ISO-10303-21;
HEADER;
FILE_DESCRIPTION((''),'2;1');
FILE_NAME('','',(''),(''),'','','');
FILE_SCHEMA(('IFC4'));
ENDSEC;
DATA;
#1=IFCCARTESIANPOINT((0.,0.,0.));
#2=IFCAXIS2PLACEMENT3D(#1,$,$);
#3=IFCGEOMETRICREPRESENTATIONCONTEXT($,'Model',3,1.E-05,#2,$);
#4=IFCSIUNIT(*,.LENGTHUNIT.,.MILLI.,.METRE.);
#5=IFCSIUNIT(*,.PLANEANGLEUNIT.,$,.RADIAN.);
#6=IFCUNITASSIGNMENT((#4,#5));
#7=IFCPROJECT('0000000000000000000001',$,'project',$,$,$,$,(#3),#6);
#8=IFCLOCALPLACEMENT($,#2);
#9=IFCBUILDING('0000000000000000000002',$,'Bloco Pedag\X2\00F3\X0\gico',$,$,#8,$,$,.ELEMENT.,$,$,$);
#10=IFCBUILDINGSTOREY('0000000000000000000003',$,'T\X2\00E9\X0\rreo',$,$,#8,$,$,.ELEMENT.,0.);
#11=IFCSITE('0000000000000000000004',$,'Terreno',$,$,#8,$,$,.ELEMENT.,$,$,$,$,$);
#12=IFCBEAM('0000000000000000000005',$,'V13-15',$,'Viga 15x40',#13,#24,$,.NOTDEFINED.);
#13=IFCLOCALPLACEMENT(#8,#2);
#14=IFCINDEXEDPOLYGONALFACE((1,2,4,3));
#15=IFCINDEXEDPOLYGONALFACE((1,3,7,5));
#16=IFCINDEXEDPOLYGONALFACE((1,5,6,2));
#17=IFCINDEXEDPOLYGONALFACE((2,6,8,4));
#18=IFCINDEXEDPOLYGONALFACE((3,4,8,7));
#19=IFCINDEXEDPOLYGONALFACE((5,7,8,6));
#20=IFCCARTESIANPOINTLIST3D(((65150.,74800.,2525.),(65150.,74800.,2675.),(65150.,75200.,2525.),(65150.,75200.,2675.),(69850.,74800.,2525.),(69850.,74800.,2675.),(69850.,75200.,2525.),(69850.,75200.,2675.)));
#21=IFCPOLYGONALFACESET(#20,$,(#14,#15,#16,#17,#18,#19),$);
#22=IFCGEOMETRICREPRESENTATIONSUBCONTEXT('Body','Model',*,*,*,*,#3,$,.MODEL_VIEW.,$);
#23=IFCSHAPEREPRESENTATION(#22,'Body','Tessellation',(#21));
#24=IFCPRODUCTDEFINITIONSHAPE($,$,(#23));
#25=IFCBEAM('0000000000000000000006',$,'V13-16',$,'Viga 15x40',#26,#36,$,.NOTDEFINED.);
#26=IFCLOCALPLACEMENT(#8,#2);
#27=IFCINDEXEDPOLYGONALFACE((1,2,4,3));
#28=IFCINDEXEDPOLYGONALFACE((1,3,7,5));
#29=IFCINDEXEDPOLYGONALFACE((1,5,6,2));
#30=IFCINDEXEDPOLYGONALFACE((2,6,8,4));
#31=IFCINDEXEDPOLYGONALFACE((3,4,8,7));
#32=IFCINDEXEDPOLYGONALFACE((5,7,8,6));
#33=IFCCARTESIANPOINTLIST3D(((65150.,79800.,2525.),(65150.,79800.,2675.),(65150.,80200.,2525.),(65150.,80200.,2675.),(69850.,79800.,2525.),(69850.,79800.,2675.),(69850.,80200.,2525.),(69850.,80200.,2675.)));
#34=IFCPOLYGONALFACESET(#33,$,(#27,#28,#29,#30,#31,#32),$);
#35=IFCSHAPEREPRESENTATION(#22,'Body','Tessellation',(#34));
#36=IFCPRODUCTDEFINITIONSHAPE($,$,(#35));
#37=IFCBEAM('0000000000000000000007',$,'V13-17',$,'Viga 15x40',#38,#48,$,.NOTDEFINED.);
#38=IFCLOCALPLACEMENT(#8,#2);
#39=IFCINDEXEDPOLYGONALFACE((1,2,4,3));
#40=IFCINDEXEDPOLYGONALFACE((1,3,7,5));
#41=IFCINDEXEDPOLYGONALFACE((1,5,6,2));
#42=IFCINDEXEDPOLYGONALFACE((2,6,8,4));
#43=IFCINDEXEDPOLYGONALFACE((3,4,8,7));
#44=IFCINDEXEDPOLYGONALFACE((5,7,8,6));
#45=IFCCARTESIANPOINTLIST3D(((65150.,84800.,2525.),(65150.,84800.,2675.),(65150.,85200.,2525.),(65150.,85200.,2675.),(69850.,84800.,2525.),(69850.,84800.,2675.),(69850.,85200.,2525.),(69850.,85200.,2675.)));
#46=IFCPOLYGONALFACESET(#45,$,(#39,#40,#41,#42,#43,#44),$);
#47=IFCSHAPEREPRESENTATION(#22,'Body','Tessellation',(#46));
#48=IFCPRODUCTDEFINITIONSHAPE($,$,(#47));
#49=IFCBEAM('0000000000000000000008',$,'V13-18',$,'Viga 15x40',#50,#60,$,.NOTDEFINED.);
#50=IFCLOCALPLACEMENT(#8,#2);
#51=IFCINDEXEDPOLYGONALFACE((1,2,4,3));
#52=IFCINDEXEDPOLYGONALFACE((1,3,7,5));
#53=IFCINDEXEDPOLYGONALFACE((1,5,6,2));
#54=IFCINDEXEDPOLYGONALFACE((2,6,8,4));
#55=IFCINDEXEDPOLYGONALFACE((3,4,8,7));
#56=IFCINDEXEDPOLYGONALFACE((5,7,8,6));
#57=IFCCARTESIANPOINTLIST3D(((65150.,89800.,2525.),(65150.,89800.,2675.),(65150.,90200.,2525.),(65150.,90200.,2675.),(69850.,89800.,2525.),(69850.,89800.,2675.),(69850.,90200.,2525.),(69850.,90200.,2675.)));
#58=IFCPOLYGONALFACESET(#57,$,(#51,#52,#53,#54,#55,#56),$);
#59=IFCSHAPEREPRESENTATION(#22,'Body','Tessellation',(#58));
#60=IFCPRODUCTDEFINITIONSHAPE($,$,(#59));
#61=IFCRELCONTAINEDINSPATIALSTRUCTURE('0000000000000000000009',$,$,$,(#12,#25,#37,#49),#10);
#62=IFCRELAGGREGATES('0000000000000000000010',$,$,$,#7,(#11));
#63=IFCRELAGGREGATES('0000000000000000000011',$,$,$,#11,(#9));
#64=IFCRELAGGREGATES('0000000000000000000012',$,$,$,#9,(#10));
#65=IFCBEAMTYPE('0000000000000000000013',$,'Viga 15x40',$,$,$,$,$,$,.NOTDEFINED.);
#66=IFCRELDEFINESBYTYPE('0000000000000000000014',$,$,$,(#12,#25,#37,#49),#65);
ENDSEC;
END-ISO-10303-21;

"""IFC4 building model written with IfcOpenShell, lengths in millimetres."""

from ifc_helpers import new_model, si_unit, frame, origin, origin_2d, place, context, subcontext, project, spatial, rectangle, extrude, type_object, element, save


model = new_model("IFC4")

# Units and contexts
model_context = context("Model", 3, precision=1e-05, world=origin())
body_context = subcontext(model_context, "Body", "Model", "MODEL_VIEW")
ifc_project = project(units=[si_unit("LENGTHUNIT", "METRE", prefix="MILLI"), si_unit("PLANEANGLEUNIT", "RADIAN")], contexts=[model_context])

# Site, building, storey
placement = place(None, origin())
site = spatial("IfcSite", under=ifc_project, at=placement, Name="Terreno", CompositionType="ELEMENT")
building = spatial("IfcBuilding", under=site, at=placement, Name="Bloco Pedagógico", CompositionType="ELEMENT")
storey = spatial("IfcBuildingStorey", under=building, at=placement, Name="Térreo", CompositionType="ELEMENT", Elevation=0.0)

# Beams
beam_type = type_object("IfcBeamType", Name="Viga 15x40", PredefinedType="NOTDEFINED")
for number, where, z_axis, x_axis, name in (
    (1, (65150.0, 75000.0, 2600.0), (1.0, 0.0, 0.0), (0.0, 1.0, 0.0), "V13-15"),
    (2, (65150.0, 80000.0, 2600.0), (1.0, 0.0, 0.0), (0.0, 1.0, 0.0), "V13-16"),
    (3, (65150.0, 85000.0, 2600.0), (1.0, 0.0, 0.0), (0.0, 1.0, 0.0), "V13-17"),
    (4, (65150.0, 90000.0, 2600.0), (1.0, 0.0, 0.0), (0.0, 1.0, 0.0), "V13-18"),
):
    element("IfcBeam", number, at=place(None, frame(where, z_axis=z_axis, x_axis=x_axis)), inside=storey, type_object=beam_type, Name=name, ObjectType="Viga 15x40", PredefinedType="NOTDEFINED", context=body_context, shape_type="SweptSolid", body=[
        extrude(rectangle(XDim=400.0, YDim=150.0, at=origin_2d()), None, (0.0, 0.0, 1.0), 4700.0),
    ])

save(model, "model.ifc")
